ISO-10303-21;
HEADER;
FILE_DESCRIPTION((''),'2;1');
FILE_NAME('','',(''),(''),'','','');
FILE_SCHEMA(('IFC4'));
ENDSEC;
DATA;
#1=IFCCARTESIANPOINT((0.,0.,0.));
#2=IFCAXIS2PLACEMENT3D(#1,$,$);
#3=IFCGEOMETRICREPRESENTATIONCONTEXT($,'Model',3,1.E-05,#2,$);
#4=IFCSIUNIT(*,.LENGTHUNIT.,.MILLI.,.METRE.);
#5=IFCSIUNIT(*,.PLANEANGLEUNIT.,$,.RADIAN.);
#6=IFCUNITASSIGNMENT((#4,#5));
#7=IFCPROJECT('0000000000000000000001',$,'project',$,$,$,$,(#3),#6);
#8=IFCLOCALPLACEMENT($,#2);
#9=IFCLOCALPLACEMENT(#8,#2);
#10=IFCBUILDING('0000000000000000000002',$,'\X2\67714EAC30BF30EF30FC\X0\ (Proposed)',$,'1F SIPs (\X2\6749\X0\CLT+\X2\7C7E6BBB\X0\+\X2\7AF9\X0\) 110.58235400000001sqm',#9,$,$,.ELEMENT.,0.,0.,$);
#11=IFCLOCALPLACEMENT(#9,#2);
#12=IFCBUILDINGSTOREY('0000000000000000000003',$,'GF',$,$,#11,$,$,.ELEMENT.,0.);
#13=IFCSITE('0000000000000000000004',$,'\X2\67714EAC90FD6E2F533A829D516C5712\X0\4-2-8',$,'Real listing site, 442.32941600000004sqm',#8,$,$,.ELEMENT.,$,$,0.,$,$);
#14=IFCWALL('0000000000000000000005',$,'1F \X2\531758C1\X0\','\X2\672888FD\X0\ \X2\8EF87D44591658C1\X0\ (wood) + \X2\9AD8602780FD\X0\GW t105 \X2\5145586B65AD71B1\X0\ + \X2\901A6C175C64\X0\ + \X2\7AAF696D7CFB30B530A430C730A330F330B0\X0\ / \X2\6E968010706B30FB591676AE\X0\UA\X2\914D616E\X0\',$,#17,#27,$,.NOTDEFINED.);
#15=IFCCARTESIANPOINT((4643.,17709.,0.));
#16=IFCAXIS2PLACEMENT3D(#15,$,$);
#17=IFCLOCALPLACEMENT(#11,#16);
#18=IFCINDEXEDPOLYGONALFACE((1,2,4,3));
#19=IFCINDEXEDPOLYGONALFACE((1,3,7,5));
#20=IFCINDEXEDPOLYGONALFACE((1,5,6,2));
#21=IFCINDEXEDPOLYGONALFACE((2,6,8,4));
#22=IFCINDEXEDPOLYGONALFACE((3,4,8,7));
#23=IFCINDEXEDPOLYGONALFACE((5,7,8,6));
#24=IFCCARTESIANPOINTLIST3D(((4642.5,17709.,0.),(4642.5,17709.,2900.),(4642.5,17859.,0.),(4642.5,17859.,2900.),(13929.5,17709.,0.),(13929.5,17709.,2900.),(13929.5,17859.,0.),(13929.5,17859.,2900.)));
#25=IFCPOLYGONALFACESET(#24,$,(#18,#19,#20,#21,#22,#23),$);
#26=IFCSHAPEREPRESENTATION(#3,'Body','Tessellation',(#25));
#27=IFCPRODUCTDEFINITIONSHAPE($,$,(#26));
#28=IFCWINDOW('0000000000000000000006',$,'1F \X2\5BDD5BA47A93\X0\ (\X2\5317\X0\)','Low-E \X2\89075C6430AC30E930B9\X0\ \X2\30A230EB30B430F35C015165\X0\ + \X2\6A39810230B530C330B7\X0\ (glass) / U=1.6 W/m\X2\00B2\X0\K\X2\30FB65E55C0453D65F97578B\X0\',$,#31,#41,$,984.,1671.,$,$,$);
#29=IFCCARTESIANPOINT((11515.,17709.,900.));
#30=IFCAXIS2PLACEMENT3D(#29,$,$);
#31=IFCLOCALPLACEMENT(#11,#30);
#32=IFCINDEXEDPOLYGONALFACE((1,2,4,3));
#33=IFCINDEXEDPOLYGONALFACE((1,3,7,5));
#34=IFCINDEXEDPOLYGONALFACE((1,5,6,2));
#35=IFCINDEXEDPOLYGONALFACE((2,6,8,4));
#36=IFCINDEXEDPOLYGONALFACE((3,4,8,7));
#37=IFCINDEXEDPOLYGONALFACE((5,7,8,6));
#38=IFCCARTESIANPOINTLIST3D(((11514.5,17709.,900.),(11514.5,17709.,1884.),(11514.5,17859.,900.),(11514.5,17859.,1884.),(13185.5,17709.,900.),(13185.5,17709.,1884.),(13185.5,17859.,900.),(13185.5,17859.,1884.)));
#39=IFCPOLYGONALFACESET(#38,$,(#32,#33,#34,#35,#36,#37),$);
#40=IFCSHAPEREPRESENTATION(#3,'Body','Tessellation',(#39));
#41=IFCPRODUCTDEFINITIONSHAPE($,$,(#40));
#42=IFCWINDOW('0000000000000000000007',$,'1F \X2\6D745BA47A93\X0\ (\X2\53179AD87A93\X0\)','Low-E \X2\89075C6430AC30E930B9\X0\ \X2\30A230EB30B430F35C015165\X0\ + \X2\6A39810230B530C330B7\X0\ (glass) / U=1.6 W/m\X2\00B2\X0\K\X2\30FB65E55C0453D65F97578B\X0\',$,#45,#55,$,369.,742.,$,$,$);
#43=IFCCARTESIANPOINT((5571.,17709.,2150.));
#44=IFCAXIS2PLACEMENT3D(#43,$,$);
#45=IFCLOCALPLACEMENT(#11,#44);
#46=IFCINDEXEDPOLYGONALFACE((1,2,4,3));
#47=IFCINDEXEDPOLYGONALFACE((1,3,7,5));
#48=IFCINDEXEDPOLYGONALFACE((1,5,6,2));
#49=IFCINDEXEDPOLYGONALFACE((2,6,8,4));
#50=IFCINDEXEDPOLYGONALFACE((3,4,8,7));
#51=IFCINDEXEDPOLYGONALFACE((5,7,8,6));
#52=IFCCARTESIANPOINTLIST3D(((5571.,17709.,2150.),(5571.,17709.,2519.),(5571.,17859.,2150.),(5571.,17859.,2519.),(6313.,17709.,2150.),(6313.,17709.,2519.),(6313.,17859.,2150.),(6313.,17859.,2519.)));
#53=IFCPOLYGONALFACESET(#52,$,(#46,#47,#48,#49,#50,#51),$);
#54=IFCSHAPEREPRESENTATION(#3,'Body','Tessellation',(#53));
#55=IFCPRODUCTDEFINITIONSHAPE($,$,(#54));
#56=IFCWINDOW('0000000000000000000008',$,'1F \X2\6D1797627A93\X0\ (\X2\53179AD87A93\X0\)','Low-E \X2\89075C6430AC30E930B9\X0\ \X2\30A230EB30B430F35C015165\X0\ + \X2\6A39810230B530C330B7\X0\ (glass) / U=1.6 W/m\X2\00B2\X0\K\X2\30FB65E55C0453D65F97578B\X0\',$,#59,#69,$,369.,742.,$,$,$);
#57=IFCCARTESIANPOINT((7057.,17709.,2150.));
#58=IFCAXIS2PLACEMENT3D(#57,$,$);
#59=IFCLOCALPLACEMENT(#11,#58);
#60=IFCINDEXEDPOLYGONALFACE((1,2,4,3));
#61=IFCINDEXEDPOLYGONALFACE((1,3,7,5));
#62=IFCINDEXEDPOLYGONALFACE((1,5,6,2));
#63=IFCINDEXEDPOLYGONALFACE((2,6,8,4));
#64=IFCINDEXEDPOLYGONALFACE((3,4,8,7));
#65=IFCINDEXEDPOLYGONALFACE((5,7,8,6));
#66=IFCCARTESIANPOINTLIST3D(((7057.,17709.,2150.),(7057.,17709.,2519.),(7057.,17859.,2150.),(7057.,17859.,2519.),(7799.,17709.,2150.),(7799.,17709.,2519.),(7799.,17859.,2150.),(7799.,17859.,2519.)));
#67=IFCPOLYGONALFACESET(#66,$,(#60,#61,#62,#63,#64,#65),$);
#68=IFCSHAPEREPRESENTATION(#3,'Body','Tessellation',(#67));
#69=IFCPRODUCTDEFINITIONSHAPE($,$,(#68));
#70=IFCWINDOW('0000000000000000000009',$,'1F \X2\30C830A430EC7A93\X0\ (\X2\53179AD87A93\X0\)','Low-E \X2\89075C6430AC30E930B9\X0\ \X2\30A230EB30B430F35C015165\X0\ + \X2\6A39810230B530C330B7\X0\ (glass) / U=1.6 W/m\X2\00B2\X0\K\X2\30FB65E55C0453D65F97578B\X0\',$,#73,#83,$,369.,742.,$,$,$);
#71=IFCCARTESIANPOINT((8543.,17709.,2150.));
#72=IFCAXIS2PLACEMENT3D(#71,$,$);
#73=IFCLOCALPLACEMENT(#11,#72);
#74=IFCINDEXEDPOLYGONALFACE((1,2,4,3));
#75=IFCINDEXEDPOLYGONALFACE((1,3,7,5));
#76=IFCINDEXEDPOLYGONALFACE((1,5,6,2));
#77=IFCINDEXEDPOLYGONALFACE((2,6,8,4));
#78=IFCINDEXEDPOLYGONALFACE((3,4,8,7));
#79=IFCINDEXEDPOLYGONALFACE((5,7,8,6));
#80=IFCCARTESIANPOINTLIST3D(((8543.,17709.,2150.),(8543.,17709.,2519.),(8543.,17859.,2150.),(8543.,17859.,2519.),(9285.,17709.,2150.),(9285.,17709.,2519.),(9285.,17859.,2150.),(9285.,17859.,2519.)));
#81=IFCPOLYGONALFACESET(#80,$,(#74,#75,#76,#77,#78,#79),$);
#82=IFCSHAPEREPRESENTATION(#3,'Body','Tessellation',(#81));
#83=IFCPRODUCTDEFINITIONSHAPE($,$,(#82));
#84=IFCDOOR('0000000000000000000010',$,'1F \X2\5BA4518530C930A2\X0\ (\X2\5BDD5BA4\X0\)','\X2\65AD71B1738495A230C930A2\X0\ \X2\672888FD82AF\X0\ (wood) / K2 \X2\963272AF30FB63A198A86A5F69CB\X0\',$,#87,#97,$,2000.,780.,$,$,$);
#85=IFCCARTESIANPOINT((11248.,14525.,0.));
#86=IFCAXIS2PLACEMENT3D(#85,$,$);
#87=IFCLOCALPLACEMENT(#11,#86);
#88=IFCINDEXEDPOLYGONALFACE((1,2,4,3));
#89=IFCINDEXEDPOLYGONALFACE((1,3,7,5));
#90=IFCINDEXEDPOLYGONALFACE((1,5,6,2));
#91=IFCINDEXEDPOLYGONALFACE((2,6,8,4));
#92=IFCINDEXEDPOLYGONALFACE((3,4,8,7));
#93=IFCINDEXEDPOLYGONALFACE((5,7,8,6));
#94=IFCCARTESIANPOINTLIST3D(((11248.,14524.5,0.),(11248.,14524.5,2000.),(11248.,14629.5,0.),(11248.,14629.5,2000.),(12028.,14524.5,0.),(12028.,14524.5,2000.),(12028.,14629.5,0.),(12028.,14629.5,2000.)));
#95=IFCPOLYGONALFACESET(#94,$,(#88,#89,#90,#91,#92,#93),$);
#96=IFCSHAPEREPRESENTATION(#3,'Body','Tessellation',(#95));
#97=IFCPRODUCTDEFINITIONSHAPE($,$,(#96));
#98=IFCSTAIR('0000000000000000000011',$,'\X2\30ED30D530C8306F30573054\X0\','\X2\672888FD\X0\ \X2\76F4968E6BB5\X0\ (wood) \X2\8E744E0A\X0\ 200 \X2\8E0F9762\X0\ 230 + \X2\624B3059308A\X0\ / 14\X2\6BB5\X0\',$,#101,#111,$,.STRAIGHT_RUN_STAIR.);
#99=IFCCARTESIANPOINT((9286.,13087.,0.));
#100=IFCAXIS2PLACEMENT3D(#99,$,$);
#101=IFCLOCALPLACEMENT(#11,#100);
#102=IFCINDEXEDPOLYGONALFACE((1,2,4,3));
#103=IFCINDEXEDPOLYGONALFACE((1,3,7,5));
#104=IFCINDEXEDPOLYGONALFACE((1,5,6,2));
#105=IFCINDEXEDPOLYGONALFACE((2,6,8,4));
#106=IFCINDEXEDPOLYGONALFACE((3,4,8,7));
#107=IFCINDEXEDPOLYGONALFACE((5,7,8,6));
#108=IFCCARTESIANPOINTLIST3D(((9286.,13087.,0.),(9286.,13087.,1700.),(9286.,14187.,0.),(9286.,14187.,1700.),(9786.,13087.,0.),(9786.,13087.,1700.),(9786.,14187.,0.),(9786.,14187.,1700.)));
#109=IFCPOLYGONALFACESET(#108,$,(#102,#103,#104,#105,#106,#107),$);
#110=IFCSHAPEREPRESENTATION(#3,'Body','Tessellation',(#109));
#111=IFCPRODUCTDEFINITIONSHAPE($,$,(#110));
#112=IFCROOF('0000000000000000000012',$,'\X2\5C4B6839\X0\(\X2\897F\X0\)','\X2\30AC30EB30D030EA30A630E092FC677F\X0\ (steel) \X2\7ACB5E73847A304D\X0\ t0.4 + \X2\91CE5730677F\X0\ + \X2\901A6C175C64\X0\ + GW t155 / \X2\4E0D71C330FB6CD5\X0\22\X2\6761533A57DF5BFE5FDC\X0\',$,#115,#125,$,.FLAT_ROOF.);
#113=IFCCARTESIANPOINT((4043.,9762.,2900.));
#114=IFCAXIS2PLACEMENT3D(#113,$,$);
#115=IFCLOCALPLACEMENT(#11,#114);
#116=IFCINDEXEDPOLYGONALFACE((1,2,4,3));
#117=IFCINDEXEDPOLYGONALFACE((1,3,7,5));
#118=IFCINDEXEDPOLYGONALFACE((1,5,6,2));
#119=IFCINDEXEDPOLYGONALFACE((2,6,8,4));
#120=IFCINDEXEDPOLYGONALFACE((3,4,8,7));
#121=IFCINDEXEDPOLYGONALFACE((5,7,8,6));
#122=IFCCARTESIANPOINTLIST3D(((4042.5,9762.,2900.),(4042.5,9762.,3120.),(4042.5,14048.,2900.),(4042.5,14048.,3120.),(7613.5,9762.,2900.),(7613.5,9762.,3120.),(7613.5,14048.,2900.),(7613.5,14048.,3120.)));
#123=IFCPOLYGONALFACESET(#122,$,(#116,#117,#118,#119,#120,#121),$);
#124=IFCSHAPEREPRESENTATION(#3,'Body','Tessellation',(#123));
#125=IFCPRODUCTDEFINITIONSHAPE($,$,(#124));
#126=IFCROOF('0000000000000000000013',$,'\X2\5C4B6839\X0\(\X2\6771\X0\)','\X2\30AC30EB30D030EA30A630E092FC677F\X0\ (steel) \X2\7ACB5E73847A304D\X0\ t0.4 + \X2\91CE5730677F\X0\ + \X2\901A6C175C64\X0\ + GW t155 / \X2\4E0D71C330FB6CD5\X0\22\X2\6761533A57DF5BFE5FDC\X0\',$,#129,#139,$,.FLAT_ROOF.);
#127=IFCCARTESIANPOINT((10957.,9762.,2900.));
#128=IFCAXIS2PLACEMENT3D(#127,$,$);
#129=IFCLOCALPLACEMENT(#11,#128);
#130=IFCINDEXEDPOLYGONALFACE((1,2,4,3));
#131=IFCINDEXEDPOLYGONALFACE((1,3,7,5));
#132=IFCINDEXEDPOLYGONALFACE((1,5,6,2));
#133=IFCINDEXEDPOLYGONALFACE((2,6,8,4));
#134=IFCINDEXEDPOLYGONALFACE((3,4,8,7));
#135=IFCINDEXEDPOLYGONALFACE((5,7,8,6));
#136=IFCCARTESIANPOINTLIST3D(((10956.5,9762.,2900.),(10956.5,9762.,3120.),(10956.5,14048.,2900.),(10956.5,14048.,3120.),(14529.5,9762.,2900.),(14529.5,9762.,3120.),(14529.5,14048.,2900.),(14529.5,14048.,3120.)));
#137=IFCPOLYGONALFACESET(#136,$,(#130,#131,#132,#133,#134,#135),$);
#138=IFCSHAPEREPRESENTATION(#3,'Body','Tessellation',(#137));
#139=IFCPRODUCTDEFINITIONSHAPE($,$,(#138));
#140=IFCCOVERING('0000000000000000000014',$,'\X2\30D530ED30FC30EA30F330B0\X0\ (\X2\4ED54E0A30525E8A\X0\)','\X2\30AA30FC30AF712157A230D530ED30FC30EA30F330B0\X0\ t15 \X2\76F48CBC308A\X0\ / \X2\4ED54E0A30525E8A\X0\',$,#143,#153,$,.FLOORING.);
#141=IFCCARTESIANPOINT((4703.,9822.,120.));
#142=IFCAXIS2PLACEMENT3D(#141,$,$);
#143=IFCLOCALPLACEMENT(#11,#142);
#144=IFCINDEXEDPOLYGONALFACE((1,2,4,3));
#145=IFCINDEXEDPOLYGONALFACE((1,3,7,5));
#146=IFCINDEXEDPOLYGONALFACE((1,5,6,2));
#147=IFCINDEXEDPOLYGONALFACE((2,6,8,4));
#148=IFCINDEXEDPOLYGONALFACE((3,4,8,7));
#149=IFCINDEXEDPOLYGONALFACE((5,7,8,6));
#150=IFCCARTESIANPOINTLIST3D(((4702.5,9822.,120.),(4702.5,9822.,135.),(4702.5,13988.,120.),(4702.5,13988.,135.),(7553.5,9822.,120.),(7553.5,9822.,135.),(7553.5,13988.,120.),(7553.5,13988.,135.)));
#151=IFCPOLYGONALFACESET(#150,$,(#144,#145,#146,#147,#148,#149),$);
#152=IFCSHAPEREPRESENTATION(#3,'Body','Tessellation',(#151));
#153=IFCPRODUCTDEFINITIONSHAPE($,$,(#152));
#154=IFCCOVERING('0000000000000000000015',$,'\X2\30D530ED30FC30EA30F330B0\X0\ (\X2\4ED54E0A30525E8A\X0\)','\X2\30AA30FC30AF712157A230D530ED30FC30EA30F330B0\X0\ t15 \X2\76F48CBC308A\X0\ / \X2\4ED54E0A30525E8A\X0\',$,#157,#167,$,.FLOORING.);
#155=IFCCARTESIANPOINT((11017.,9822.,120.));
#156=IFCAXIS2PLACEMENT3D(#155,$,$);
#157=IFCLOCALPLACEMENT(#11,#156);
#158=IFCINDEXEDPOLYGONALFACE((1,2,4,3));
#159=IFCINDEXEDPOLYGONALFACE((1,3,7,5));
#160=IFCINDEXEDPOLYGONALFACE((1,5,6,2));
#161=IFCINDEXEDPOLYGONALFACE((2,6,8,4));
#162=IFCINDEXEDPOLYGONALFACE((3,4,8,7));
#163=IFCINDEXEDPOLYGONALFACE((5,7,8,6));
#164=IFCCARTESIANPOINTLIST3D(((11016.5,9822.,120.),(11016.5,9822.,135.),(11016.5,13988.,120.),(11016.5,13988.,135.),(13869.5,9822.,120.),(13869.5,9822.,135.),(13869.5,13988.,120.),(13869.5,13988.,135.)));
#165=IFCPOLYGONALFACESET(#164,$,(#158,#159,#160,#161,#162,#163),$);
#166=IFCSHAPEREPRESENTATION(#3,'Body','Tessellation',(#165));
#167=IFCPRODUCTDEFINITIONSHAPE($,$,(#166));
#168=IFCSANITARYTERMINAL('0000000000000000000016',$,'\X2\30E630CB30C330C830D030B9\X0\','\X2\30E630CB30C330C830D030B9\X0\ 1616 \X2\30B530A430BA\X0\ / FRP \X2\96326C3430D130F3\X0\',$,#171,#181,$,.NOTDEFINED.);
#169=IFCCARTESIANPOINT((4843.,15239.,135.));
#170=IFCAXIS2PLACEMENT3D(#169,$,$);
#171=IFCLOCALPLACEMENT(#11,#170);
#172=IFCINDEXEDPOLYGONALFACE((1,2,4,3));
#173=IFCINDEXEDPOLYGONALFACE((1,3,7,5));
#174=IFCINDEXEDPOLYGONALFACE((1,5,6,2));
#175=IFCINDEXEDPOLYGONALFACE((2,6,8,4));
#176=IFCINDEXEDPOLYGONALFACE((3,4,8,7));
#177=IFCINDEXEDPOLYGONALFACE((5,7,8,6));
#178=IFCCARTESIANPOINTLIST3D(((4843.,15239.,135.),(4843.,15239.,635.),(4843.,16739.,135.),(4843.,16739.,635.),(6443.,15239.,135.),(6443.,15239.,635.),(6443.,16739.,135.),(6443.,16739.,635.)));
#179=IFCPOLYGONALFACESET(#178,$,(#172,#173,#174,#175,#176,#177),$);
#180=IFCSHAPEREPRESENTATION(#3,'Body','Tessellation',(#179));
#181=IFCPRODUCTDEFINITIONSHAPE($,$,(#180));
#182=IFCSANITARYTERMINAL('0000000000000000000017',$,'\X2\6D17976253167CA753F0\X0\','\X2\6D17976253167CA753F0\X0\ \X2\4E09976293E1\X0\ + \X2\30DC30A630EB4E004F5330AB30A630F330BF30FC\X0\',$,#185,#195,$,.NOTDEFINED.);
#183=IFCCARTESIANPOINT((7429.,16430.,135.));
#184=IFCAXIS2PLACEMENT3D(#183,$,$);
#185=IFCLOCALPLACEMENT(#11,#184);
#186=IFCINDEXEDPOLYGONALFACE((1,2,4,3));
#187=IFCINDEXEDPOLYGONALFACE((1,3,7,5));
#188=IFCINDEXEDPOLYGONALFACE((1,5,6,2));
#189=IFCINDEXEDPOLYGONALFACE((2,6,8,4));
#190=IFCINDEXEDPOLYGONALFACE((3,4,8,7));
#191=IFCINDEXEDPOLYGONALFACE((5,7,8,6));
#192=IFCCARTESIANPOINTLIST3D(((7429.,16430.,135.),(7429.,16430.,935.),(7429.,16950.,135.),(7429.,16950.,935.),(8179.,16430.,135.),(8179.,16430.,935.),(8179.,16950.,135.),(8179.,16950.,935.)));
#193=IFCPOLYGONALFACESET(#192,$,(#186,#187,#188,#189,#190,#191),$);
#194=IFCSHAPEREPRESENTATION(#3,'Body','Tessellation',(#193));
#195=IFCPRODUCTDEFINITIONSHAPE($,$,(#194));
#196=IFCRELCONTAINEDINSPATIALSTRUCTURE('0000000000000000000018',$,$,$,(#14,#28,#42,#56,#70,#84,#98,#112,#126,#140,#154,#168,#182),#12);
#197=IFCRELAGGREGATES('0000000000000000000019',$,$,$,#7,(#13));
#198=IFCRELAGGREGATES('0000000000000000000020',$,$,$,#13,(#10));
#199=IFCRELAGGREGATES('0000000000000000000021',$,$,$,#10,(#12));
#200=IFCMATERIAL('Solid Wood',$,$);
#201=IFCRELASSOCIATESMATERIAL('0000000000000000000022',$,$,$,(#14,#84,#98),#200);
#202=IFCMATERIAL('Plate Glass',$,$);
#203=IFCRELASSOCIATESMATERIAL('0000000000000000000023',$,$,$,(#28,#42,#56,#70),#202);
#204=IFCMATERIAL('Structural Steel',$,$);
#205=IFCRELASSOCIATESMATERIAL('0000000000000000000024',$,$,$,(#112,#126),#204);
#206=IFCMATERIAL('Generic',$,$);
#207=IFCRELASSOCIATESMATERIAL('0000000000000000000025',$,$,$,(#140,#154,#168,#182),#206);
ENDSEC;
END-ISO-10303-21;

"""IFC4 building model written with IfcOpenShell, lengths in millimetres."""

from ifc_helpers import new_model, si_unit, frame, frame_2d, origin, place, context, project, spatial, rectangle, extrude, material, element, fill, save


model = new_model("IFC4")

# Units and contexts
model_context = context("Model", 3, precision=1e-05, world=origin())
ifc_project = project(units=[si_unit("LENGTHUNIT", "METRE", prefix="MILLI"), si_unit("PLANEANGLEUNIT", "RADIAN")], contexts=[model_context])

# Site, building, storey
site_placement = place(None, origin())
site = spatial("IfcSite", under=ifc_project, at=site_placement, Name="東京都港区芝公園4-2-8", ObjectType="Real listing site, 442.32941600000004sqm", CompositionType="ELEMENT", RefElevation=0.0)
building_placement = place(site_placement, origin())
building = spatial("IfcBuilding", under=site, at=building_placement, Name="東京タワー (Proposed)", ObjectType="1F SIPs (杉CLT+籾殻+竹) 110.58235400000001sqm", CompositionType="ELEMENT", ElevationOfRefHeight=0.0, ElevationOfTerrain=0.0)
storey_placement = place(building_placement, origin())
storey = spatial("IfcBuildingStorey", under=building, at=storey_placement, Name="GF", CompositionType="ELEMENT", Elevation=0.0)

# Shared definitions
ifc_material_1 = material(Name="Solid Wood")

# Wall, openings, windows
wall_1_placement = place(storey_placement, frame((4643.0, 17709.0, 0.0)))
wall_1 = element("IfcWall", 1, at=wall_1_placement, inside=storey, material=ifc_material_1, Name="1F 北壁", Description="木製 軸組外壁 (wood) + 高性能GW t105 充填断熱 + 通気層 + 窯業系サイディング / 準耐火・外皮UA配慮", PredefinedType="NOTDEFINED", context=model_context, shape_type="SweptSolid", body=[
    extrude(rectangle(XDim=9287.0, YDim=150.0, at=frame_2d((4643.0, 75.0))), frame((4643.0, 17709.0, 0.0)), (0.0, 0.0, 1.0), 2900.0),
])
opening_1_placement = place(storey_placement, frame((11515.0, 17709.0, 900.0)))
opening_1 = element("IfcOpeningElement", 2, at=opening_1_placement, cuts=wall_1, PredefinedType="NOTDEFINED", context=model_context, shape_type="SweptSolid", body=[
    extrude(rectangle(XDim=1671.0, YDim=150.0, at=frame_2d((835.0, 75.0))), frame((11515.0, 17709.0, 900.0)), (0.0, 0.0, 1.0), 984.0),
])
opening_2_placement = place(storey_placement, frame((5571.0, 17709.0, 2150.0)))
opening_2 = element("IfcOpeningElement", 3, at=opening_2_placement, cuts=wall_1, PredefinedType="NOTDEFINED", context=model_context, shape_type="SweptSolid", body=[
    extrude(rectangle(XDim=742.0, YDim=150.0, at=frame_2d((371.0, 75.0))), frame((5571.0, 17709.0, 2150.0)), (0.0, 0.0, 1.0), 369.0),
])
opening_3_placement = place(storey_placement, frame((7057.0, 17709.0, 2150.0)))
opening_3 = element("IfcOpeningElement", 4, at=opening_3_placement, cuts=wall_1, PredefinedType="NOTDEFINED", context=model_context, shape_type="SweptSolid", body=[
    extrude(rectangle(XDim=742.0, YDim=150.0, at=frame_2d((371.0, 75.0))), frame((7057.0, 17709.0, 2150.0)), (0.0, 0.0, 1.0), 369.0),
])
opening_4_placement = place(storey_placement, frame((8543.0, 17709.0, 2150.0)))
opening_4 = element("IfcOpeningElement", 5, at=opening_4_placement, cuts=wall_1, PredefinedType="NOTDEFINED", context=model_context, shape_type="SweptSolid", body=[
    extrude(rectangle(XDim=742.0, YDim=150.0, at=frame_2d((371.0, 75.0))), frame((8543.0, 17709.0, 2150.0)), (0.0, 0.0, 1.0), 369.0),
])
ifc_material_2 = material(Name="Plate Glass")
window_1_placement = place(storey_placement, frame((11515.0, 17709.0, 900.0)))
window_1 = element("IfcWindow", 6, at=window_1_placement, inside=storey, material=ifc_material_2, Name="1F 寝室窓 (北)", Description="Low-E 複層ガラス アルゴン封入 + 樹脂サッシ (glass) / U=1.6 W/m²K・日射取得型", OverallHeight=984.0, OverallWidth=1671.0, context=model_context, shape_type="SweptSolid", body=[
    extrude(rectangle(XDim=1671.0, YDim=150.0, at=frame_2d((835.0, 75.0))), frame((11515.0, 17709.0, 900.0)), (0.0, 0.0, 1.0), 984.0),
])
fill(opening_1, window_1)
window_2_placement = place(storey_placement, frame((5571.0, 17709.0, 2150.0)))
window_2 = element("IfcWindow", 7, at=window_2_placement, inside=storey, material=ifc_material_2, Name="1F 浴室窓 (北高窓)", Description="Low-E 複層ガラス アルゴン封入 + 樹脂サッシ (glass) / U=1.6 W/m²K・日射取得型", OverallHeight=369.0, OverallWidth=742.0, context=model_context, shape_type="SweptSolid", body=[
    extrude(rectangle(XDim=742.0, YDim=150.0, at=frame_2d((371.0, 75.0))), frame((5571.0, 17709.0, 2150.0)), (0.0, 0.0, 1.0), 369.0),
])
fill(opening_2, window_2)
window_3_placement = place(storey_placement, frame((7057.0, 17709.0, 2150.0)))
window_3 = element("IfcWindow", 8, at=window_3_placement, inside=storey, material=ifc_material_2, Name="1F 洗面窓 (北高窓)", Description="Low-E 複層ガラス アルゴン封入 + 樹脂サッシ (glass) / U=1.6 W/m²K・日射取得型", OverallHeight=369.0, OverallWidth=742.0, context=model_context, shape_type="SweptSolid", body=[
    extrude(rectangle(XDim=742.0, YDim=150.0, at=frame_2d((371.0, 75.0))), frame((7057.0, 17709.0, 2150.0)), (0.0, 0.0, 1.0), 369.0),
])
fill(opening_3, window_3)
window_4_placement = place(storey_placement, frame((8543.0, 17709.0, 2150.0)))
window_4 = element("IfcWindow", 9, at=window_4_placement, inside=storey, material=ifc_material_2, Name="1F トイレ窓 (北高窓)", Description="Low-E 複層ガラス アルゴン封入 + 樹脂サッシ (glass) / U=1.6 W/m²K・日射取得型", OverallHeight=369.0, OverallWidth=742.0, context=model_context, shape_type="SweptSolid", body=[
    extrude(rectangle(XDim=742.0, YDim=150.0, at=frame_2d((371.0, 75.0))), frame((8543.0, 17709.0, 2150.0)), (0.0, 0.0, 1.0), 369.0),
])
fill(opening_4, window_4)

# Door
door_1_placement = place(storey_placement, frame((11248.0, 14525.0, 0.0)))
element("IfcDoor", 10, at=door_1_placement, inside=storey, material=ifc_material_1, Name="1F 室内ドア (寝室)", Description="断熱玄関ドア 木製芯 (wood) / K2 防犯・採風機構", OverallHeight=2000.0, OverallWidth=780.0, context=model_context, shape_type="SweptSolid", body=[
    extrude(rectangle(XDim=780.0, YDim=105.0, at=frame_2d((390.0, 52.0))), frame((11248.0, 14525.0, 0.0)), (0.0, 0.0, 1.0), 2000.0),
])

# Stair
stair_placement = place(storey_placement, frame((9286.0, 13087.0, 0.0)))
element("IfcStair", 11, at=stair_placement, inside=storey, material=ifc_material_1, Name="ロフトはしご", Description="木製 直階段 (wood) 蹴上 200 踏面 230 + 手すり / 14段", PredefinedType="STRAIGHT_RUN_STAIR", context=model_context, shape_type="SweptSolid", body=[
    extrude(rectangle(XDim=500.0, YDim=1100.0, at=frame_2d((250.0, 550.0))), frame((9286.0, 13087.0, 0.0)), (0.0, 0.0, 1.0), 1700.0),
])

# Roofs
ifc_material_3 = material(Name="Structural Steel")
roof_1_placement = place(storey_placement, frame((4043.0, 9762.0, 2900.0)))
element("IfcRoof", 12, at=roof_1_placement, inside=storey, material=ifc_material_3, Name="屋根(西)", Description="ガルバリウム鋼板 (steel) 立平葺き t0.4 + 野地板 + 通気層 + GW t155 / 不燃・法22条区域対応", PredefinedType="FLAT_ROOF", context=model_context, shape_type="SweptSolid", body=[
    extrude(rectangle(XDim=3571.0, YDim=4286.0, at=frame_2d((1785.0, 2143.0))), frame((4043.0, 9762.0, 2900.0)), (0.0, 0.0, 1.0), 220.0),
])
roof_2_placement = place(storey_placement, frame((10957.0, 9762.0, 2900.0)))
element("IfcRoof", 13, at=roof_2_placement, inside=storey, material=ifc_material_3, Name="屋根(東)", Description="ガルバリウム鋼板 (steel) 立平葺き t0.4 + 野地板 + 通気層 + GW t155 / 不燃・法22条区域対応", PredefinedType="FLAT_ROOF", context=model_context, shape_type="SweptSolid", body=[
    extrude(rectangle(XDim=3573.0, YDim=4286.0, at=frame_2d((1786.0, 2143.0))), frame((10957.0, 9762.0, 2900.0)), (0.0, 0.0, 1.0), 220.0),
])

# Coverings
ifc_material_4 = material(Name="Generic")
covering_1_placement = place(storey_placement, frame((4703.0, 9822.0, 120.0)))
element("IfcCovering", 14, at=covering_1_placement, inside=storey, material=ifc_material_4, Name="フローリング (仕上げ床)", Description="オーク無垢フローリング t15 直貼り / 仕上げ床", PredefinedType="FLOORING", context=model_context, shape_type="SweptSolid", body=[
    extrude(rectangle(XDim=2851.0, YDim=4166.0, at=frame_2d((1425.0, 2083.0))), frame((4703.0, 9822.0, 120.0)), (0.0, 0.0, 1.0), 15.0),
])
covering_2_placement = place(storey_placement, frame((11017.0, 9822.0, 120.0)))
element("IfcCovering", 15, at=covering_2_placement, inside=storey, material=ifc_material_4, Name="フローリング (仕上げ床)", Description="オーク無垢フローリング t15 直貼り / 仕上げ床", PredefinedType="FLOORING", context=model_context, shape_type="SweptSolid", body=[
    extrude(rectangle(XDim=2853.0, YDim=4166.0, at=frame_2d((1426.0, 2083.0))), frame((11017.0, 9822.0, 120.0)), (0.0, 0.0, 1.0), 15.0),
])

# Sanitary terminals
sanitary_terminal_1_placement = place(storey_placement, frame((4843.0, 15239.0, 135.0)))
element("IfcSanitaryTerminal", 16, at=sanitary_terminal_1_placement, inside=storey, material=ifc_material_4, Name="ユニットバス", Description="ユニットバス 1616 サイズ / FRP 防水パン", PredefinedType="NOTDEFINED", context=model_context, shape_type="SweptSolid", body=[
    extrude(rectangle(XDim=1600.0, YDim=1500.0, at=frame_2d((800.0, 750.0))), frame((4843.0, 15239.0, 135.0)), (0.0, 0.0, 1.0), 500.0),
])
sanitary_terminal_2_placement = place(storey_placement, frame((7429.0, 16430.0, 135.0)))
element("IfcSanitaryTerminal", 17, at=sanitary_terminal_2_placement, inside=storey, material=ifc_material_4, Name="洗面化粧台", Description="洗面化粧台 三面鏡 + ボウル一体カウンター", PredefinedType="NOTDEFINED", context=model_context, shape_type="SweptSolid", body=[
    extrude(rectangle(XDim=750.0, YDim=520.0, at=frame_2d((375.0, 260.0))), frame((7429.0, 16430.0, 135.0)), (0.0, 0.0, 1.0), 800.0),
])

save(model, "model.ifc")
